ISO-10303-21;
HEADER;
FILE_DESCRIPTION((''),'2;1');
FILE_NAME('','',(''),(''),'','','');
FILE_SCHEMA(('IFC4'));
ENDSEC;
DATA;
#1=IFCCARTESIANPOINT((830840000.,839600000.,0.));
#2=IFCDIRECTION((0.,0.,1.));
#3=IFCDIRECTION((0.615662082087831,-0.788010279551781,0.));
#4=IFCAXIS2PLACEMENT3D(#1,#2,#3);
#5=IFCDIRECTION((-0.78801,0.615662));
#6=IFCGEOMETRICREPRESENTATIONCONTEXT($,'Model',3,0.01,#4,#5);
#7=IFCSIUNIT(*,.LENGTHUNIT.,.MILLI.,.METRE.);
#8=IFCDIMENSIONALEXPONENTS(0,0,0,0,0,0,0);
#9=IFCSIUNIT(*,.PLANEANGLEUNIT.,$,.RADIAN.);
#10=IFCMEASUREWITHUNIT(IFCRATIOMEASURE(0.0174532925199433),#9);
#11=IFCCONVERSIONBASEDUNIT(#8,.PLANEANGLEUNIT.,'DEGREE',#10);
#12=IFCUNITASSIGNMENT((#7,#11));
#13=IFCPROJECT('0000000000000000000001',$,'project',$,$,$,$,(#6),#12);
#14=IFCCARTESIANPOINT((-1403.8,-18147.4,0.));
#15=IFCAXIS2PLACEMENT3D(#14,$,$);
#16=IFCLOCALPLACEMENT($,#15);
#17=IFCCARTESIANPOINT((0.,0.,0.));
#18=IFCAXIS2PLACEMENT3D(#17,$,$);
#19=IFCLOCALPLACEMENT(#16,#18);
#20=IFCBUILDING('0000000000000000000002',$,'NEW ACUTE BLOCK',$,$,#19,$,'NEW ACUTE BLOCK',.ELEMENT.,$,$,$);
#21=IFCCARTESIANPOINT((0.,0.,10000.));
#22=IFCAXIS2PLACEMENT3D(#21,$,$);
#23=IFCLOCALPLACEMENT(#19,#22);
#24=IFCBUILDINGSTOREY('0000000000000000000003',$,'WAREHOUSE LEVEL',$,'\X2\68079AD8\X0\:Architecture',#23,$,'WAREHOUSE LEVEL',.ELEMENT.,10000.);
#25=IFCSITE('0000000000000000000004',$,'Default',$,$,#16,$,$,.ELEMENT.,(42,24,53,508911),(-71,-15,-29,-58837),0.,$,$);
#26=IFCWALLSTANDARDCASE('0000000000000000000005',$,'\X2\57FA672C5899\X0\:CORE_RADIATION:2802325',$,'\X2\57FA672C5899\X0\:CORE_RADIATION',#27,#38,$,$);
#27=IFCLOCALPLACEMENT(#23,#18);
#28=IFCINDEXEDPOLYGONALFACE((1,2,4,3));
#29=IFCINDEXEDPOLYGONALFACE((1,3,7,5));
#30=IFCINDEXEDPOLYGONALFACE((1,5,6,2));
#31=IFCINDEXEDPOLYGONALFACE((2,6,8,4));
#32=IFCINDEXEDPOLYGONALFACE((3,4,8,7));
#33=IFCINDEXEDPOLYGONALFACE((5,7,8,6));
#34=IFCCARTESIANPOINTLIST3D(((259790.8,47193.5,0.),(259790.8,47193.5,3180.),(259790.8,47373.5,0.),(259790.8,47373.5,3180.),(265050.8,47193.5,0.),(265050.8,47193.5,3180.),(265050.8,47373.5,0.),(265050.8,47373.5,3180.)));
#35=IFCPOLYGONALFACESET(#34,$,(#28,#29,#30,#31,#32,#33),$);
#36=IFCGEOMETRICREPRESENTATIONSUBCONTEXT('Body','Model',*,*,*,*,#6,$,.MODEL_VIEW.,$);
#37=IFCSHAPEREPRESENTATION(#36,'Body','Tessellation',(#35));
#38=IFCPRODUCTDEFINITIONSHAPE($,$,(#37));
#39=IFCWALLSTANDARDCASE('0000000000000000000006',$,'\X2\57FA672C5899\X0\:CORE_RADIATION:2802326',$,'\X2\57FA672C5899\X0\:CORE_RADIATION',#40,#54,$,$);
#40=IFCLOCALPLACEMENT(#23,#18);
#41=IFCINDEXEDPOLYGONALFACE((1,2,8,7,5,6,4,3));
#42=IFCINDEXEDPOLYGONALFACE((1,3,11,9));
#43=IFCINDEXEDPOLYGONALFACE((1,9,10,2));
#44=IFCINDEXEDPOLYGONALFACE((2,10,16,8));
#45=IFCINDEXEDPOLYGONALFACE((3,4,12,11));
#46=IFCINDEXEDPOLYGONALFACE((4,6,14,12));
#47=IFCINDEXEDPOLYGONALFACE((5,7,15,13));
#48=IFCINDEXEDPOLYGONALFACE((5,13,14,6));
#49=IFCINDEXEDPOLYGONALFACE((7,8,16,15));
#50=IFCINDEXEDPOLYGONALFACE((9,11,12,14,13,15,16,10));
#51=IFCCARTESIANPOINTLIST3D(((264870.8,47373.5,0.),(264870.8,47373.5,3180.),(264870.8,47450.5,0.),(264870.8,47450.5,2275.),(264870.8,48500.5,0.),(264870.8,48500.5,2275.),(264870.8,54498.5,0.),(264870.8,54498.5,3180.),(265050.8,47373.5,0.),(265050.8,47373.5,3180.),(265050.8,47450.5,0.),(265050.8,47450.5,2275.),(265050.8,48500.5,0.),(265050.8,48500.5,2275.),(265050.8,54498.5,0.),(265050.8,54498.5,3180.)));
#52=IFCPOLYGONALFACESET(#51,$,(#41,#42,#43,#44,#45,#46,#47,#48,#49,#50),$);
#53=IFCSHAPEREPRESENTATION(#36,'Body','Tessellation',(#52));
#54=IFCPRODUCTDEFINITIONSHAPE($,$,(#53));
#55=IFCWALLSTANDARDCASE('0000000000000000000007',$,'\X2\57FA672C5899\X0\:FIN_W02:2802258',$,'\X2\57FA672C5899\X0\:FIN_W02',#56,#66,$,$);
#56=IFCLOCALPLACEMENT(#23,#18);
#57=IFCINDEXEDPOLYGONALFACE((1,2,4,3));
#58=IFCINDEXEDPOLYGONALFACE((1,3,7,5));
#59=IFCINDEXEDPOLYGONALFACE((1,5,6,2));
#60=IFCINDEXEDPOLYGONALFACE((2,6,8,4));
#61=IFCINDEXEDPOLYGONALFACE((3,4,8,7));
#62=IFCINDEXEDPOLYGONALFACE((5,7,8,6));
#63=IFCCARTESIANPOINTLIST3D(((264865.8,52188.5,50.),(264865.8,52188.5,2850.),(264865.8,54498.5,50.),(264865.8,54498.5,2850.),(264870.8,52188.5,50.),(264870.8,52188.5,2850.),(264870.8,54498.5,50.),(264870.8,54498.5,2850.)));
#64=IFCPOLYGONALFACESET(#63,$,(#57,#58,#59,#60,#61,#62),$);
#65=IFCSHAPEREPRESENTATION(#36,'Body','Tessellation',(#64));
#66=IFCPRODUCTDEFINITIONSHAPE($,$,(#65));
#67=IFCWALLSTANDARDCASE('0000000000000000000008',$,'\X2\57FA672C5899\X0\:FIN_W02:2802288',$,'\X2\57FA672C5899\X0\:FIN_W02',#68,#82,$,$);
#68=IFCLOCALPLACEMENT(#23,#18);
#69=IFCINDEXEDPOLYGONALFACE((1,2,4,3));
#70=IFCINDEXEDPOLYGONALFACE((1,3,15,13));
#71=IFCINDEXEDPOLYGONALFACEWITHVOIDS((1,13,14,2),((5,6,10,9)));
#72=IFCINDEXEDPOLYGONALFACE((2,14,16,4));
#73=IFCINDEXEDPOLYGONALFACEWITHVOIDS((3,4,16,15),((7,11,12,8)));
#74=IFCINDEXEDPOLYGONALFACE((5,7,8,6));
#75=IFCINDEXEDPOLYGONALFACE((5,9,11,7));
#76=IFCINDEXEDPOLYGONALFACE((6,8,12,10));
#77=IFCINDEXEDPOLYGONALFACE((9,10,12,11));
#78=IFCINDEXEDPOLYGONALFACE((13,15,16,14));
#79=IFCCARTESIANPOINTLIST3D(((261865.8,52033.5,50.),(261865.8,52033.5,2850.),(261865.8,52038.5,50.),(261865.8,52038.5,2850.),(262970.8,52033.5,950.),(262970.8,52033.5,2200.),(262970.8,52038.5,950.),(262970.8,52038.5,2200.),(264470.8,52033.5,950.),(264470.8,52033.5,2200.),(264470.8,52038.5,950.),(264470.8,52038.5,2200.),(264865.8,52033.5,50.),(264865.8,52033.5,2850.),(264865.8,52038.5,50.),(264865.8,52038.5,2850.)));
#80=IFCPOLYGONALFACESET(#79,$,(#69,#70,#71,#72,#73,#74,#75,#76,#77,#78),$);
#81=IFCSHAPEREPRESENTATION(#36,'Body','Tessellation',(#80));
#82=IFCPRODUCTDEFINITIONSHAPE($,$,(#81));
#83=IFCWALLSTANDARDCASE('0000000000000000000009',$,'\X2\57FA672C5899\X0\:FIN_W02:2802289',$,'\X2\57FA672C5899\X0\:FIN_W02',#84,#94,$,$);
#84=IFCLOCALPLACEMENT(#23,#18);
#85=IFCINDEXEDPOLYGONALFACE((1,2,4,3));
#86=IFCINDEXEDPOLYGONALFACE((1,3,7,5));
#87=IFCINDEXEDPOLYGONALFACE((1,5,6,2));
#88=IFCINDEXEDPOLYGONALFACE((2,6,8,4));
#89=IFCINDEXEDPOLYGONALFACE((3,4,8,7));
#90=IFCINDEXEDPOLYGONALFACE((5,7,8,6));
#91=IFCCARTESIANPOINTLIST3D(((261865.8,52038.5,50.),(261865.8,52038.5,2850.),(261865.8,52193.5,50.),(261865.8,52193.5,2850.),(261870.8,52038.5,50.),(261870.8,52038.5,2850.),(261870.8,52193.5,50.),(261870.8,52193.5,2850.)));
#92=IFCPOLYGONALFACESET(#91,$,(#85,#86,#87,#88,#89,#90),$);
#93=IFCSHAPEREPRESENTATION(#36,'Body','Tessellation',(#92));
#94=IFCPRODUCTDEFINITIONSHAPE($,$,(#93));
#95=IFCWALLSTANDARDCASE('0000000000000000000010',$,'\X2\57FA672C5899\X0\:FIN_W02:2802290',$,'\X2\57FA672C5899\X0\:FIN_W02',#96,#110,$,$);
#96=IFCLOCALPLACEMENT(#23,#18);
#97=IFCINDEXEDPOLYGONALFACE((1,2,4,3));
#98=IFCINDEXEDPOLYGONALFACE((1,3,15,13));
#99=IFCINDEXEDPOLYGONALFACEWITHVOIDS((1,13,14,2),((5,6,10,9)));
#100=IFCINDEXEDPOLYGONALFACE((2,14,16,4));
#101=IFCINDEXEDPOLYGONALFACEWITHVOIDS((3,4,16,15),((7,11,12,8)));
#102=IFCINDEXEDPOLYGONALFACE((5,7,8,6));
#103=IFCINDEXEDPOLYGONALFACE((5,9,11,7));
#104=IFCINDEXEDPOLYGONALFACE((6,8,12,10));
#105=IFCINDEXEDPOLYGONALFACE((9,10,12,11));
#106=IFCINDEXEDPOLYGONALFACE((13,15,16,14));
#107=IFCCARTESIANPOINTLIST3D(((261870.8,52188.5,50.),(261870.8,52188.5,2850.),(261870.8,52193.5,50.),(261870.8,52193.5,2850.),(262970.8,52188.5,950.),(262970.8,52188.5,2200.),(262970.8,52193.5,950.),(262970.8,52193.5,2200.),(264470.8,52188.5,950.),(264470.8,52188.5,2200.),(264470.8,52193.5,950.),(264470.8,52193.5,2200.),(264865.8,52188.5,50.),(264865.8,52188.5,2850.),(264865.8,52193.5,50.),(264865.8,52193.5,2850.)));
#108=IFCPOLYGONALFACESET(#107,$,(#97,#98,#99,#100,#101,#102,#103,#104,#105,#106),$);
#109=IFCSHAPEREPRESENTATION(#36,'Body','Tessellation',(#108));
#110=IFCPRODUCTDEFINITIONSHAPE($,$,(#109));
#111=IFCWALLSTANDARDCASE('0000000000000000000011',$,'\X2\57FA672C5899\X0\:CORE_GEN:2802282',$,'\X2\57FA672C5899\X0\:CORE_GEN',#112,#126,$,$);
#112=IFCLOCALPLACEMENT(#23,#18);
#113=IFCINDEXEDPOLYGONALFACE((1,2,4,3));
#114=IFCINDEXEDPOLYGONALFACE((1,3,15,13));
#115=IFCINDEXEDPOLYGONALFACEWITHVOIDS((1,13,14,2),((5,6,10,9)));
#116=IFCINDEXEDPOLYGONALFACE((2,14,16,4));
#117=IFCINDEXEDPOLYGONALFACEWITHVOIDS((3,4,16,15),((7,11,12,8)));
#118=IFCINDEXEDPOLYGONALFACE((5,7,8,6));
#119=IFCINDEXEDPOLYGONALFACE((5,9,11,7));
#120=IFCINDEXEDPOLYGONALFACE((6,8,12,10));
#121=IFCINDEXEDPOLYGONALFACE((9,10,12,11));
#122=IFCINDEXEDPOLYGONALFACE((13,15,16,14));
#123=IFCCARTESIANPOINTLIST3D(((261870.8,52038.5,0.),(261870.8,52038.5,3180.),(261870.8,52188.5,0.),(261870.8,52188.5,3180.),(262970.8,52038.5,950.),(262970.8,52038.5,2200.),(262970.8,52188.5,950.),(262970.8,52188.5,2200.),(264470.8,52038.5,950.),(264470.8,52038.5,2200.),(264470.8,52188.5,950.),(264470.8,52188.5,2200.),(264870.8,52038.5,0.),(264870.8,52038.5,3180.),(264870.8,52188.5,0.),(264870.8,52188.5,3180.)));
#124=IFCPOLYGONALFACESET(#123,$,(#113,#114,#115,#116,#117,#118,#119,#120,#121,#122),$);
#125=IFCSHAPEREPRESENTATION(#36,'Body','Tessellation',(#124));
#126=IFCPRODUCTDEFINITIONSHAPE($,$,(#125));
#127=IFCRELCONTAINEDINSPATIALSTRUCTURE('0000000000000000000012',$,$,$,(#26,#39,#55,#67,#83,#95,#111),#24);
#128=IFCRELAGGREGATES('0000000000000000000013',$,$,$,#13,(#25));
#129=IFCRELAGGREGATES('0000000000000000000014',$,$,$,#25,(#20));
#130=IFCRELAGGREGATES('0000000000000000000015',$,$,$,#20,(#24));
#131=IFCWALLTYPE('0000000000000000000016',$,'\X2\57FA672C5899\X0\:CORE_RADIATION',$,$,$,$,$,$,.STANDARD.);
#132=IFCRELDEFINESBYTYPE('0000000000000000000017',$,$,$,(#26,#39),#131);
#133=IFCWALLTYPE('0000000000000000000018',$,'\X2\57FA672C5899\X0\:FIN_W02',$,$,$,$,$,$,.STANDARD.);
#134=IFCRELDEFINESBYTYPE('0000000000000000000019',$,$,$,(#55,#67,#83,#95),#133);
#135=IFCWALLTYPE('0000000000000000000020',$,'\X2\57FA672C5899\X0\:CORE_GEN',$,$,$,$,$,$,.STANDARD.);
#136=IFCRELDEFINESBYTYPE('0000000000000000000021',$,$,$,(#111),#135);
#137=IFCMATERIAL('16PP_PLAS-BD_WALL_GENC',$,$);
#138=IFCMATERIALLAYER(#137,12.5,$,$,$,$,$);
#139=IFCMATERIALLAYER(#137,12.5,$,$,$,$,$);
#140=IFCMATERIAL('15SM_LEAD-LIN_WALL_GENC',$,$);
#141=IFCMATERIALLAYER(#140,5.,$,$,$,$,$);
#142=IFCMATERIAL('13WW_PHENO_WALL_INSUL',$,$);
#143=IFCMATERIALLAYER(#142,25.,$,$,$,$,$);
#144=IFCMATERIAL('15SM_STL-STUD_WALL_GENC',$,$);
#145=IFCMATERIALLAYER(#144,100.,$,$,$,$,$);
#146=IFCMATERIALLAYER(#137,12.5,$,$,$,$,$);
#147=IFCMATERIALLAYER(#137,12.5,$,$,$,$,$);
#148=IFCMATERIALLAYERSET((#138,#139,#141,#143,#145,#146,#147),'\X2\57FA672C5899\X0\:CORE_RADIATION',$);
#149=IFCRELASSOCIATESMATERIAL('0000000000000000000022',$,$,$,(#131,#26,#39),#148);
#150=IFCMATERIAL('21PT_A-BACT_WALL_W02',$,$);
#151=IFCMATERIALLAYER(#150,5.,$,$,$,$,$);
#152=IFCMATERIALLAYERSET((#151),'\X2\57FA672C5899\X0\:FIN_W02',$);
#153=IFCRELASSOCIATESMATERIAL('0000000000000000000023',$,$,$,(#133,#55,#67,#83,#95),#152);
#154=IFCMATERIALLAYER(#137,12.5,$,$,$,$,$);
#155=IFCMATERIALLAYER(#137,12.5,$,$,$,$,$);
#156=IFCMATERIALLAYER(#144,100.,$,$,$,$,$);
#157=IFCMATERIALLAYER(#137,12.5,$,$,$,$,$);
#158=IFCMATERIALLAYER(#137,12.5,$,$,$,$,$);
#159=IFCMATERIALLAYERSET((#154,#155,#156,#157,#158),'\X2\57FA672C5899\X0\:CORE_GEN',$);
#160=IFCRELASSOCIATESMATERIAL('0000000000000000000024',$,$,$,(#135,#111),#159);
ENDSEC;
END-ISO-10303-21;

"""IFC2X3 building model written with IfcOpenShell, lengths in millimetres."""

from ifc_helpers import new_model, entity, si_unit, converted_unit, direction, frame, frame_2d, origin, place, context, subcontext, project, spatial, rectangle, extrude, material, layer, layer_set, layer_usage, type_object, element, save


model = new_model("IFC2X3")

# Units and contexts
model_context = context("Model", 3, precision=0.01, world=frame((830840000.0, 839600000.0, 0.0), z_axis=(0.0, 0.0, 1.0), x_axis=(0.615662082087831, -0.788010279551781, 0.0)), true_north=direction((-0.78801, 0.615662)))
body_context = subcontext(model_context, "Body", "Model", "MODEL_VIEW")
ifc_project = project(units=[si_unit("LENGTHUNIT", "METRE", prefix="MILLI"), converted_unit("PLANEANGLEUNIT", "DEGREE", entity("IfcRatioMeasure", 0.0174532925199433), si_unit("PLANEANGLEUNIT", "RADIAN"), dimensions=[0, 0, 0, 0, 0, 0, 0])], contexts=[model_context])

# Site, building, storey
site_placement = place(None, frame((-1403.8, -18147.4, 0.0)))
site = spatial("IfcSite", under=ifc_project, at=site_placement, Name="Default", CompositionType="ELEMENT", RefLatitude=(42, 24, 53, 508911), RefLongitude=(-71, -15, -29, -58837), RefElevation=0.0)
building_placement = place(site_placement, origin())
building = spatial("IfcBuilding", under=site, at=building_placement, Name="NEW ACUTE BLOCK", LongName="NEW ACUTE BLOCK", CompositionType="ELEMENT")
storey_placement = place(building_placement, frame((0.0, 0.0, 10000.0)))
storey = spatial("IfcBuildingStorey", under=building, at=storey_placement, Name="WAREHOUSE LEVEL", ObjectType="标高:Architecture", LongName="WAREHOUSE LEVEL", CompositionType="ELEMENT", Elevation=10000.0)

# Wall
ifc_material_1 = material(Name="16PP_PLAS-BD_WALL_GENC")
ifc_layer_1 = layer(ifc_material_1, 12.5)
ifc_layer_2 = layer(ifc_material_1, 12.5)
ifc_material_2 = material(Name="15SM_LEAD-LIN_WALL_GENC")
ifc_layer_3 = layer(ifc_material_2, 5.0)
ifc_material_3 = material(Name="13WW_PHENO_WALL_INSUL")
ifc_layer_4 = layer(ifc_material_3, 25.0)
ifc_material_4 = material(Name="15SM_STL-STUD_WALL_GENC")
ifc_layer_5 = layer(ifc_material_4, 100.0)
ifc_layer_6 = layer(ifc_material_1, 12.5)
ifc_layer_7 = layer(ifc_material_1, 12.5)
ifc_layer_set_1 = layer_set([ifc_layer_1, ifc_layer_2, ifc_layer_3, ifc_layer_4, ifc_layer_5, ifc_layer_6, ifc_layer_7], Name="基本墙:CORE_RADIATION")
ifc_layer_usage_1 = layer_usage(ifc_layer_set_1, "AXIS2", "NEGATIVE", 90.0)
wall_type_1 = type_object("IfcWallType", Name="基本墙:CORE_RADIATION", PredefinedType="STANDARD", material=ifc_layer_set_1)
wall_1_placement = place(storey_placement, frame((265050.8, 47283.5, 0.0), z_axis=(0.0, 0.0, 1.0), x_axis=(-1.0, 0.0, 0.0)))
element("IfcWallStandardCase", 1, at=wall_1_placement, inside=storey, type_object=wall_type_1, material=ifc_layer_usage_1, Name="基本墙:CORE_RADIATION:2802325", ObjectType="基本墙:CORE_RADIATION", context=body_context, shape_type="SweptSolid", body=[
    extrude(rectangle(XDim=5260.0, YDim=180.0, at=frame_2d((2630.0, 0.0), x_axis=(-1.0, 0.0))), origin(), (0.0, 0.0, 1.0), 3180.0),
])

# Wall, opening
ifc_layer_usage_2 = layer_usage(ifc_layer_set_1, "AXIS2", "NEGATIVE", 90.0)
wall_2_placement = place(storey_placement, frame((264960.8, 47373.5, 0.0), z_axis=(0.0, 0.0, 1.0), x_axis=(0.0, 1.0, 0.0)))
wall_2 = element("IfcWallStandardCase", 2, at=wall_2_placement, inside=storey, type_object=wall_type_1, material=ifc_layer_usage_2, Name="基本墙:CORE_RADIATION:2802326", ObjectType="基本墙:CORE_RADIATION", context=body_context, shape_type="SweptSolid", body=[
    extrude(rectangle(XDim=7125.0, YDim=180.0, at=frame_2d((3562.5, 0.0), x_axis=(-1.0, 0.0))), origin(), (0.0, 0.0, 1.0), 3180.0),
])
opening_1_placement = place(wall_2_placement, frame((77.0, 90.0, 0.0), z_axis=(0.0, 0.0, 1.0), x_axis=(0.0, -1.0, 0.0)))
element("IfcOpeningElement", 3, at=opening_1_placement, cuts=wall_2, ObjectType="Opening", context=body_context, shape_type="SweptSolid", body=[
    extrude(rectangle(XDim=2275.0, YDim=1050.0, at=frame_2d((0.0, 0.0), x_axis=(1.0, 0.0))), frame((180.0, 525.0, 1137.5), z_axis=(-1.0, 0.0, 0.0), x_axis=(0.0, 0.0, -1.0)), (0.0, 0.0, 1.0), 180.0),
])

# Shared definitions
ifc_material_5 = material(Name="21PT_A-BACT_WALL_W02")
ifc_layer_8 = layer(ifc_material_5, 5.0)
ifc_layer_set_2 = layer_set([ifc_layer_8], Name="基本墙:FIN_W02")
wall_type_2 = type_object("IfcWallType", Name="基本墙:FIN_W02", PredefinedType="STANDARD", material=ifc_layer_set_2)

# Wall
ifc_layer_usage_3 = layer_usage(ifc_layer_set_2, "AXIS2", "POSITIVE", -2.5)
wall_3_placement = place(storey_placement, frame((264868.3, 54498.5, 50.0), z_axis=(0.0, 0.0, 1.0), x_axis=(0.0, -1.0, 0.0)))
element("IfcWallStandardCase", 4, at=wall_3_placement, inside=storey, type_object=wall_type_2, material=ifc_layer_usage_3, Name="基本墙:FIN_W02:2802258", ObjectType="基本墙:FIN_W02", context=body_context, shape_type="SweptSolid", body=[
    extrude(rectangle(XDim=2310.0, YDim=5.0, at=frame_2d((1155.0, 0.0), x_axis=(-1.0, 0.0))), origin(), (0.0, 0.0, 1.0), 2800.0),
])

# Wall, openings
ifc_layer_usage_4 = layer_usage(ifc_layer_set_2, "AXIS2", "POSITIVE", -2.5)
wall_4_placement = place(storey_placement, frame((261865.8, 52036.0, 50.0)))
wall_4 = element("IfcWallStandardCase", 5, at=wall_4_placement, inside=storey, type_object=wall_type_2, material=ifc_layer_usage_4, Name="基本墙:FIN_W02:2802288", ObjectType="基本墙:FIN_W02", context=body_context, shape_type="SweptSolid", body=[
    extrude(rectangle(XDim=3000.0, YDim=5.0, at=frame_2d((1500.0, 0.0), x_axis=(-1.0, 0.0))), origin(), (0.0, 0.0, 1.0), 2800.0),
])
opening_2_placement = place(wall_4_placement, frame((1105.0, 2.5, 900.0)))
element("IfcOpeningElement", 6, at=opening_2_placement, cuts=wall_4, ObjectType="Opening", context=body_context, shape_type="SweptSolid", body=[
    extrude(rectangle(XDim=1250.0, YDim=1500.0, at=frame_2d((0.0, 0.0), x_axis=(1.0, 0.0))), frame((750.0, 0.0, 625.0), z_axis=(0.0, 1.0, 0.0), x_axis=(0.0, 0.0, -1.0)), (0.0, 0.0, 1.0), 150.0),
])
opening_3_placement = place(wall_4_placement, frame((1105.0, -97.5, 900.0)))
element("IfcOpeningElement", 7, at=opening_3_placement, cuts=wall_4, ObjectType="Opening", context=body_context, shape_type="SweptSolid", body=[
    extrude(rectangle(XDim=1250.0, YDim=1500.0, at=frame_2d((0.0, 0.0), x_axis=(1.0, 0.0))), frame((750.0, 250.0, 625.0), z_axis=(0.0, 1.0, 0.0), x_axis=(0.0, 0.0, -1.0)), (0.0, 0.0, 1.0), 100.0),
    extrude(rectangle(XDim=1250.0, YDim=1500.0, at=frame_2d((0.0, 0.0), x_axis=(1.0, 0.0))), frame((750.0, 0.0, 625.0), z_axis=(0.0, 1.0, 0.0), x_axis=(0.0, 0.0, -1.0)), (0.0, 0.0, 1.0), 100.0),
])

# Wall
ifc_layer_usage_5 = layer_usage(ifc_layer_set_2, "AXIS2", "POSITIVE", -2.5)
wall_5_placement = place(storey_placement, frame((261868.3, 52193.5, 50.0), z_axis=(0.0, 0.0, 1.0), x_axis=(0.0, -1.0, 0.0)))
element("IfcWallStandardCase", 8, at=wall_5_placement, inside=storey, type_object=wall_type_2, material=ifc_layer_usage_5, Name="基本墙:FIN_W02:2802289", ObjectType="基本墙:FIN_W02", context=body_context, shape_type="SweptSolid", body=[
    extrude(rectangle(XDim=155.0, YDim=5.0, at=frame_2d((77.5, 0.0), x_axis=(-1.0, 0.0))), origin(), (0.0, 0.0, 1.0), 2800.0),
])

# Wall, openings
ifc_layer_usage_6 = layer_usage(ifc_layer_set_2, "AXIS2", "POSITIVE", -2.5)
wall_6_placement = place(storey_placement, frame((264865.8, 52191.0, 50.0), z_axis=(0.0, 0.0, 1.0), x_axis=(-1.0, 0.0, 0.0)))
wall_6 = element("IfcWallStandardCase", 9, at=wall_6_placement, inside=storey, type_object=wall_type_2, material=ifc_layer_usage_6, Name="基本墙:FIN_W02:2802290", ObjectType="基本墙:FIN_W02", context=body_context, shape_type="SweptSolid", body=[
    extrude(rectangle(XDim=2995.0, YDim=5.0, at=frame_2d((1497.5, 0.0), x_axis=(-1.0, 0.0))), origin(), (0.0, 0.0, 1.0), 2800.0),
])
opening_4_placement = place(wall_6_placement, frame((1895.0, 152.5, 900.0)))
element("IfcOpeningElement", 10, at=opening_4_placement, cuts=wall_6, ObjectType="Opening", context=body_context, shape_type="SweptSolid", body=[
    extrude(rectangle(XDim=1250.0, YDim=1500.0, at=frame_2d((0.0, 0.0), x_axis=(0.0, 1.0))), frame((-750.0, -150.0, 625.0), z_axis=(0.0, 1.0, 0.0), x_axis=(1.0, 0.0, 0.0)), (0.0, 0.0, 1.0), 150.0),
])
opening_5_placement = place(wall_6_placement, frame((1895.0, 252.5, 900.0)))
element("IfcOpeningElement", 11, at=opening_5_placement, cuts=wall_6, ObjectType="Opening", context=body_context, shape_type="SweptSolid", body=[
    extrude(rectangle(XDim=1250.0, YDim=1500.0, at=frame_2d((0.0, 0.0), x_axis=(1.0, 0.0))), frame((-750.0, -350.0, 625.0), z_axis=(0.0, 1.0, 0.0), x_axis=(0.0, 0.0, -1.0)), (0.0, 0.0, 1.0), 100.0),
    extrude(rectangle(XDim=1250.0, YDim=1500.0, at=frame_2d((0.0, 0.0), x_axis=(1.0, 0.0))), frame((-750.0, -100.0, 625.0), z_axis=(0.0, 1.0, 0.0), x_axis=(0.0, 0.0, -1.0)), (0.0, 0.0, 1.0), 100.0),
])

# Wall, opening
ifc_layer_9 = layer(ifc_material_1, 12.5)
ifc_layer_10 = layer(ifc_material_1, 12.5)
ifc_layer_11 = layer(ifc_material_4, 100.0)
ifc_layer_12 = layer(ifc_material_1, 12.5)
ifc_layer_13 = layer(ifc_material_1, 12.5)
ifc_layer_set_3 = layer_set([ifc_layer_9, ifc_layer_10, ifc_layer_11, ifc_layer_12, ifc_layer_13], Name="基本墙:CORE_GEN")
ifc_layer_usage_7 = layer_usage(ifc_layer_set_3, "AXIS2", "NEGATIVE", 75.0)
wall_type_3 = type_object("IfcWallType", Name="基本墙:CORE_GEN", PredefinedType="STANDARD", material=ifc_layer_set_3)
wall_7_placement = place(storey_placement, frame((261870.8, 52113.5, 0.0)))
wall_7 = element("IfcWallStandardCase", 12, at=wall_7_placement, inside=storey, type_object=wall_type_3, material=ifc_layer_usage_7, Name="基本墙:CORE_GEN:2802282", ObjectType="基本墙:CORE_GEN", context=body_context, shape_type="SweptSolid", body=[
    extrude(rectangle(XDim=3000.0, YDim=150.0, at=frame_2d((1500.0, 0.0), x_axis=(-1.0, 0.0))), origin(), (0.0, 0.0, 1.0), 3180.0),
])
opening_6_placement = place(wall_7_placement, frame((1100.0, -75.0, 950.0)))
element("IfcOpeningElement", 13, at=opening_6_placement, cuts=wall_7, ObjectType="Opening", context=body_context, shape_type="SweptSolid", body=[
    extrude(rectangle(XDim=1250.0, YDim=1500.0, at=frame_2d((0.0, 0.0), x_axis=(1.0, 0.0))), frame((750.0, 0.0, 625.0), z_axis=(0.0, 1.0, 0.0), x_axis=(0.0, 0.0, -1.0)), (0.0, 0.0, 1.0), 150.0),
])

save(model, "model.ifc")
